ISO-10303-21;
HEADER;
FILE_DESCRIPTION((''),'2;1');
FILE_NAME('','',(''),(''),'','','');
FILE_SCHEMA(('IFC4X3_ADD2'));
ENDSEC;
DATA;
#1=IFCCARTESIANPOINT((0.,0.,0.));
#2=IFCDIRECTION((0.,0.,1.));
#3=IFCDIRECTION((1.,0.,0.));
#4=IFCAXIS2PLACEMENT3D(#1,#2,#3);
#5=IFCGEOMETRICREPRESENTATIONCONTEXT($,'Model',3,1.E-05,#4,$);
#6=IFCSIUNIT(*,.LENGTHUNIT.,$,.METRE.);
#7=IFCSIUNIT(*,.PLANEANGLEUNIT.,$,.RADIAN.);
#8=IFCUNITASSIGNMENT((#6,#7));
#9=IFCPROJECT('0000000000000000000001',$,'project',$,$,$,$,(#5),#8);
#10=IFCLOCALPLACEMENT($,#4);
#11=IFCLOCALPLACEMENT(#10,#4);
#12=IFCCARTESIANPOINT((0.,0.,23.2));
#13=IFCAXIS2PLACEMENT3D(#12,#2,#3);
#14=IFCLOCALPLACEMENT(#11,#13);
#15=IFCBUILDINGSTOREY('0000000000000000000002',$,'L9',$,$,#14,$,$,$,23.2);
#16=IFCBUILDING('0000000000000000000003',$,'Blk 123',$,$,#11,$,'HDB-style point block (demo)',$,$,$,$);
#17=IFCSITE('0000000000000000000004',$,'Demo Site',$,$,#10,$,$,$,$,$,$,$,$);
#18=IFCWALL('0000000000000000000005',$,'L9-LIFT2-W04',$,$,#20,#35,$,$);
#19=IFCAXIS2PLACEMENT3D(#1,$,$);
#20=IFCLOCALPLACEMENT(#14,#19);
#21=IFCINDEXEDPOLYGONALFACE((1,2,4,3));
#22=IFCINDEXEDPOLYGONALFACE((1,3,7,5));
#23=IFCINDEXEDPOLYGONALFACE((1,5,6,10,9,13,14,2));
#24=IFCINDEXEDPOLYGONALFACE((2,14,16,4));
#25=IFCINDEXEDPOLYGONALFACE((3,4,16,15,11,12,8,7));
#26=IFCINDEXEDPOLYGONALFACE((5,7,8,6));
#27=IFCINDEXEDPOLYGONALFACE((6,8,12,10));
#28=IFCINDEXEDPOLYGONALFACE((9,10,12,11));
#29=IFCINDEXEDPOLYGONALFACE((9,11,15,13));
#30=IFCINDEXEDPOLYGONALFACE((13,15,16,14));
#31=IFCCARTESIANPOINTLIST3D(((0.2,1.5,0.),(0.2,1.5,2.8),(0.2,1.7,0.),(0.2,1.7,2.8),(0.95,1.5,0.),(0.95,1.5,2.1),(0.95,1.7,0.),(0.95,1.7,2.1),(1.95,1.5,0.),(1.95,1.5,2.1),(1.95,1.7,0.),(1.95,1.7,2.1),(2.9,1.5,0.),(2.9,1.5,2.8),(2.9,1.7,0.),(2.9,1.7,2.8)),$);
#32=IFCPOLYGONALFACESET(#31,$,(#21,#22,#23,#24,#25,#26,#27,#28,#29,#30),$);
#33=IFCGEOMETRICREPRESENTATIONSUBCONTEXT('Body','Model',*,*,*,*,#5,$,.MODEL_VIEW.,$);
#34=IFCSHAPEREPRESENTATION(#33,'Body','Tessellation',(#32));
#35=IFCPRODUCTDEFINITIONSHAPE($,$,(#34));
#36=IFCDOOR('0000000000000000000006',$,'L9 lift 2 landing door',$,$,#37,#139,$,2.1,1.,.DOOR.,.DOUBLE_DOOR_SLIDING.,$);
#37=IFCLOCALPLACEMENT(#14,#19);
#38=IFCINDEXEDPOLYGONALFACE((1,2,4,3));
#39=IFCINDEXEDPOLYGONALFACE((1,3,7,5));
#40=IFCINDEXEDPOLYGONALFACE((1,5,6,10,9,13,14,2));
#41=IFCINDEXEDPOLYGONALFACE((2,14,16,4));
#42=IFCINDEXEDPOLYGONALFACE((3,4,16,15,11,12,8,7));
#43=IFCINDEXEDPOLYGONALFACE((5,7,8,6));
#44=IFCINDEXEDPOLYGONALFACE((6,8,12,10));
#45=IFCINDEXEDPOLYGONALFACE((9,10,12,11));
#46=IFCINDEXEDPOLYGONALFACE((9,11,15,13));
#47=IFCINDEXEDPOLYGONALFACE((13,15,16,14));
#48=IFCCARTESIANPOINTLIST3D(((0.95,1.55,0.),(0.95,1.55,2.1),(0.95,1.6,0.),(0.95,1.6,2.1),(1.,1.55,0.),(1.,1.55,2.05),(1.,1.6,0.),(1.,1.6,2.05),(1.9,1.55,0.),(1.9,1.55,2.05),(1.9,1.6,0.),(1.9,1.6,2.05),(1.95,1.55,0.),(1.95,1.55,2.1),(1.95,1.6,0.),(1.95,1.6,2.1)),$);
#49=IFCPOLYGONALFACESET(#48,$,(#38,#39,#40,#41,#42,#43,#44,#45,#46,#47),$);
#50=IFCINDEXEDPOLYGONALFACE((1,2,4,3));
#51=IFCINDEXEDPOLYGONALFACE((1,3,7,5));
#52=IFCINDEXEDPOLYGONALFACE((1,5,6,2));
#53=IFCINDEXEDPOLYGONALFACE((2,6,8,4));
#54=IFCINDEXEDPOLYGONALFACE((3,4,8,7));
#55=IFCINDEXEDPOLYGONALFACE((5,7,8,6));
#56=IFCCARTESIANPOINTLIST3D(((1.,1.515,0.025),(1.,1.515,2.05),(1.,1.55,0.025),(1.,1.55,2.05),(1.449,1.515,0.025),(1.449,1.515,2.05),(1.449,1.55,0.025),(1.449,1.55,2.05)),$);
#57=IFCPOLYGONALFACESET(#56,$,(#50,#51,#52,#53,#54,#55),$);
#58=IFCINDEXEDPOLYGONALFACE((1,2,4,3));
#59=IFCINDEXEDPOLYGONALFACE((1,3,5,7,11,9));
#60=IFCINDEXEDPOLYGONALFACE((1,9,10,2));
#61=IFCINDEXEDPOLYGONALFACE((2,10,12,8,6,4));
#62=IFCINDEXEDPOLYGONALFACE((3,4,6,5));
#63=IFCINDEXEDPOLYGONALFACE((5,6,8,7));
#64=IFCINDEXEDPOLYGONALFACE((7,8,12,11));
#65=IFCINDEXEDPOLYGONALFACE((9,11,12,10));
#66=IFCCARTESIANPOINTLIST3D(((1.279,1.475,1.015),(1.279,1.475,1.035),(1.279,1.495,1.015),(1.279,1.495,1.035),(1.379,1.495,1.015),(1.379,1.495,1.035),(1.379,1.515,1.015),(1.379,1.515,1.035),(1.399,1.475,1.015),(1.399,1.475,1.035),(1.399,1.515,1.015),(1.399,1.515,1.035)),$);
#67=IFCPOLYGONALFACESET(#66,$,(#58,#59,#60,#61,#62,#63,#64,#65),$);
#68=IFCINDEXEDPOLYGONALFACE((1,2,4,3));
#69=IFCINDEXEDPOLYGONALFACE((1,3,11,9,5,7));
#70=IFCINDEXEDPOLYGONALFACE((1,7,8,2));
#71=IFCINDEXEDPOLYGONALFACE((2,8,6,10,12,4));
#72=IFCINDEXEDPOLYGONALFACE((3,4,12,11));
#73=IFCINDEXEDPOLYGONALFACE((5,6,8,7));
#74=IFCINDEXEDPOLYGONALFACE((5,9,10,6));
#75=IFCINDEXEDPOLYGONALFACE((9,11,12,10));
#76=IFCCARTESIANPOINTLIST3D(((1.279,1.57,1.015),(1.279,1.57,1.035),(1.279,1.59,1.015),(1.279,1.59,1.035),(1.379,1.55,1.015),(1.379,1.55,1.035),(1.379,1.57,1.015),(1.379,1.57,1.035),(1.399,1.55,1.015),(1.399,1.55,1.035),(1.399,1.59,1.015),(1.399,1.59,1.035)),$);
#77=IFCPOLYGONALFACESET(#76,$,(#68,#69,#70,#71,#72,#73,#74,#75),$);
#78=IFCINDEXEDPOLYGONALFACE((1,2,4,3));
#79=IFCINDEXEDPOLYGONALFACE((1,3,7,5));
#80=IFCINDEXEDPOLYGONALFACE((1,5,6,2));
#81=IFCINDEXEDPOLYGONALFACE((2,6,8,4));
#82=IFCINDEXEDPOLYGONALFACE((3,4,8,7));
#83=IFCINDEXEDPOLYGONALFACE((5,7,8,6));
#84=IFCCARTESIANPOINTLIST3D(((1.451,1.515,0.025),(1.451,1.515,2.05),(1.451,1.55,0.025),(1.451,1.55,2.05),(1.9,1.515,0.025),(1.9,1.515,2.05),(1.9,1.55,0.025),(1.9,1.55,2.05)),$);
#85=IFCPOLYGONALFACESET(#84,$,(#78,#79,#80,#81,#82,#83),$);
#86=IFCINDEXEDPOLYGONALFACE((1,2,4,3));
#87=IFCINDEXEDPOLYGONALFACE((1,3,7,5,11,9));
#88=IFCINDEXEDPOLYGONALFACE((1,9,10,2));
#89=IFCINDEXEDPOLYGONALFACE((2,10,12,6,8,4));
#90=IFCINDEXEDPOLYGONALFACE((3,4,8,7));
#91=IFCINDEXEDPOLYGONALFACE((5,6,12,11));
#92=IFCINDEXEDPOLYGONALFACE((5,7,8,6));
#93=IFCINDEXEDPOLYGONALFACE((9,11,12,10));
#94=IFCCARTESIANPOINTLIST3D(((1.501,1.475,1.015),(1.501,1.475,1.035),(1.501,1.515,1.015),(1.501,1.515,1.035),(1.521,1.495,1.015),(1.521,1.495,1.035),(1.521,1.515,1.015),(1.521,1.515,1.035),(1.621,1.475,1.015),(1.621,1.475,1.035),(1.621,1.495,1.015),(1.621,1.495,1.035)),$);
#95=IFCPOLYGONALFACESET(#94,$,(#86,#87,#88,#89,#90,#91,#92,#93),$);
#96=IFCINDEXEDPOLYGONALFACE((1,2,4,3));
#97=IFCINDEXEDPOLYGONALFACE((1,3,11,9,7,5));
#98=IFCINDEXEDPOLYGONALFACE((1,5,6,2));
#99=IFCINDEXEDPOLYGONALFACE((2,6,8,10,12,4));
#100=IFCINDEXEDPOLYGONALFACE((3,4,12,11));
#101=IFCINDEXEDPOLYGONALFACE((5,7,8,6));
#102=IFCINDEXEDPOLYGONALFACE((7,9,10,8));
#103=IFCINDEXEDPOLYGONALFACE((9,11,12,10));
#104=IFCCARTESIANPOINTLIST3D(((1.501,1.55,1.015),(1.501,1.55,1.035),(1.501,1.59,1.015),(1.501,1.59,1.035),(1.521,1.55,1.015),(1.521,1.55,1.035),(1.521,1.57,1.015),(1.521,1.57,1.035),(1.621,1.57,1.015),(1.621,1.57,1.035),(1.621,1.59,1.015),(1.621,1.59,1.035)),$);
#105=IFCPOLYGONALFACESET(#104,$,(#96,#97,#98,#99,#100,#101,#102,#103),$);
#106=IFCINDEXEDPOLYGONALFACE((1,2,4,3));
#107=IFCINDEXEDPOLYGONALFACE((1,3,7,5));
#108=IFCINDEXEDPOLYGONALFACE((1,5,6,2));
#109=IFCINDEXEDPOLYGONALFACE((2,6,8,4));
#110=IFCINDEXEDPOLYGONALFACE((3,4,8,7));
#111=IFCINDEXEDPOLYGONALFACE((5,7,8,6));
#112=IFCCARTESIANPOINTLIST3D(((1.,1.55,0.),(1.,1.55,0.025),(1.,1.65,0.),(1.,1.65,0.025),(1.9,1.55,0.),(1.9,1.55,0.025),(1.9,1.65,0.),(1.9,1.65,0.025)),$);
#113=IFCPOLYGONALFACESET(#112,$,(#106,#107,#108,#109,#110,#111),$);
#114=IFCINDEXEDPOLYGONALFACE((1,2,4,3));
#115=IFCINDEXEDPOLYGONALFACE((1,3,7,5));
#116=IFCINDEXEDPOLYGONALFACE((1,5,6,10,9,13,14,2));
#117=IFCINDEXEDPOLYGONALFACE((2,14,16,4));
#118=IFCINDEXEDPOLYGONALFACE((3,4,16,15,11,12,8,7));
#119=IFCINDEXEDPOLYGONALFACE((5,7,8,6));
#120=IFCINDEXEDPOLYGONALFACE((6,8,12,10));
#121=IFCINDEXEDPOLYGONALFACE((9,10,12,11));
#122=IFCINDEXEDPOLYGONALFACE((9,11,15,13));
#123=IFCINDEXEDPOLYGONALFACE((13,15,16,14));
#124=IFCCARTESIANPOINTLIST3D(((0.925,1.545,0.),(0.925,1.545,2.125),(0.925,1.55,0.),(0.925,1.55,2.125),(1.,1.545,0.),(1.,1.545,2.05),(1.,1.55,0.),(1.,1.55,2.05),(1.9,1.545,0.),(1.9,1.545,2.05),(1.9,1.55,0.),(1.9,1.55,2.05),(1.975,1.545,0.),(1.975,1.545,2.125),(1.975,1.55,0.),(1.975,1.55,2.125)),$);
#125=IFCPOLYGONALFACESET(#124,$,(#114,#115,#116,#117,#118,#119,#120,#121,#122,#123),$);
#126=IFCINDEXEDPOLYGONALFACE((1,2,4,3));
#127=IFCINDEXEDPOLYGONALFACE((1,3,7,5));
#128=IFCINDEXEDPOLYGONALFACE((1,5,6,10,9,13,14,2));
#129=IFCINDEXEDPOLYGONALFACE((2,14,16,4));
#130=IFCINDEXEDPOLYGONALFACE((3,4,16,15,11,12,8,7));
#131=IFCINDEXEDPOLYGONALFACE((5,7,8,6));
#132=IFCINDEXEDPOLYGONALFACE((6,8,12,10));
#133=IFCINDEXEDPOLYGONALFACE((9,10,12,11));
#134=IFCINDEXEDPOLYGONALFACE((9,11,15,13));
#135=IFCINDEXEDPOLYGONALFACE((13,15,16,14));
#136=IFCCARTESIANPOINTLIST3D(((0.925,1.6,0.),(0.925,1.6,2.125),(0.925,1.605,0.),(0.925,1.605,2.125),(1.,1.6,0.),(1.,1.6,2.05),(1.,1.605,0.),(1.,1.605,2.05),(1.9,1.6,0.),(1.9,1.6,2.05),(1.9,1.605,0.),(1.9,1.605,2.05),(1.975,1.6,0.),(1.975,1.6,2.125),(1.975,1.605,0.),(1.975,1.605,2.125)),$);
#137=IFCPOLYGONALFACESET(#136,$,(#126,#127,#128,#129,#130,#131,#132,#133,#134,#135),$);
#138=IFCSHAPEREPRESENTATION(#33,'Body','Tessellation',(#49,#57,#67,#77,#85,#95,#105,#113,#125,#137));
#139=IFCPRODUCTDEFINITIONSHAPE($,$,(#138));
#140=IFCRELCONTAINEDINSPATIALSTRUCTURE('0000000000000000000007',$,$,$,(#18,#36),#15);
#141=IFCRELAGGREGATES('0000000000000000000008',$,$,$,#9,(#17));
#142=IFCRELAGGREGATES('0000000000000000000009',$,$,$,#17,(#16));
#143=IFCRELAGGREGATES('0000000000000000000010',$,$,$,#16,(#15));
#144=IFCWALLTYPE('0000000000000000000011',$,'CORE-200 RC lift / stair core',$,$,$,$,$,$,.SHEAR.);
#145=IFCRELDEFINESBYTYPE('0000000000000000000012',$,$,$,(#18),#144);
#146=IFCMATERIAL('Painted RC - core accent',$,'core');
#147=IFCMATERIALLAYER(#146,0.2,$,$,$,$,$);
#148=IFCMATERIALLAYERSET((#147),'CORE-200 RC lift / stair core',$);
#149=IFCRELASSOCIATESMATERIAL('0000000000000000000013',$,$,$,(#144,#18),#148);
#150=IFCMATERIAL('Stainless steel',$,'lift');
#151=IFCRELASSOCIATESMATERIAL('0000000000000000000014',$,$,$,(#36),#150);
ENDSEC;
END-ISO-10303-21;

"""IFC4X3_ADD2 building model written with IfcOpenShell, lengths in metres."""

from ifc_helpers import new_model, si_unit, frame, origin_with_axes, place, context, subcontext, project, spatial, line, indexed_curve, outline, extrude, material, layer, layer_set, layer_usage, type_object, element, fill, save


model = new_model("IFC4X3_ADD2")

# Units and contexts
model_context = context("Model", 3, precision=1e-05, world=origin_with_axes())
body_context = subcontext(model_context, "Body", "Model", "MODEL_VIEW")
ifc_project = project(units=[si_unit("LENGTHUNIT", "METRE"), si_unit("PLANEANGLEUNIT", "RADIAN")], contexts=[model_context])

# Site, building, storey
site_placement = place(None, origin_with_axes())
site = spatial("IfcSite", under=ifc_project, at=site_placement, Name="Demo Site")
building_placement = place(site_placement, origin_with_axes())
building = spatial("IfcBuilding", under=site, at=building_placement, Name="Blk 123", LongName="HDB-style point block (demo)")
storey_placement = place(building_placement, frame((0.0, 0.0, 23.2), z_axis=(0.0, 0.0, 1.0), x_axis=(1.0, 0.0, 0.0)))
storey = spatial("IfcBuildingStorey", under=building, at=storey_placement, Name="L9", Elevation=23.2)

# Shared definitions
ifc_material_1 = material(Name="Painted RC - core accent", Category="core")
ifc_layer_1 = layer(ifc_material_1, 0.2)
ifc_layer_set_1 = layer_set([ifc_layer_1], Name="CORE-200 RC lift / stair core")
ifc_layer_usage_1 = layer_usage(ifc_layer_set_1, "AXIS2", "POSITIVE", 0.0)
wall_type_1 = type_object("IfcWallType", Name="CORE-200 RC lift / stair core", PredefinedType="SHEAR", material=ifc_layer_set_1)

# Wall, opening, door
wall_1_placement = place(storey_placement, frame((0.2, 1.5, 0.0), z_axis=(0.0, 0.0, 1.0), x_axis=(1.0, 0.0, 0.0)))
wall_1 = element("IfcWall", 1, at=wall_1_placement, inside=storey, type_object=wall_type_1, material=ifc_layer_usage_1, Name="L9-LIFT2-W04", context=body_context, shape_type="SweptSolid", body=[
    extrude(outline(indexed_curve([(0.0, 0.0), (0.0, 0.2), (2.7, 0.2), (2.7, 0.0), (0.0, 0.0)], self_intersect=False)), origin_with_axes(), (0.0, 0.0, 1.0), 2.8),
])
opening_1_placement = place(wall_1_placement, frame((0.75, -0.1, 0.0), z_axis=(0.0, 0.0, 1.0), x_axis=(1.0, 0.0, 0.0)))
opening_1 = element("IfcOpeningElement", 2, at=opening_1_placement, cuts=wall_1, context=body_context, shape_type="SweptSolid", body=[
    extrude(outline(indexed_curve([(0.0, 0.0), (0.0, 0.4), (1.0, 0.4), (1.0, 0.0), (0.0, 0.0)], self_intersect=False)), origin_with_axes(), (0.0, 0.0, 1.0), 2.1),
])
ifc_material_2 = material(Name="Stainless steel", Category="lift")
door_1_placement = place(opening_1_placement, frame((0.0, 0.15, 0.0), z_axis=(0.0, 0.0, 1.0), x_axis=(1.0, 0.0, 0.0)))
door_1 = element("IfcDoor", 3, at=door_1_placement, inside=storey, material=ifc_material_2, Name="L9 lift 2 landing door", OperationType="DOUBLE_DOOR_SLIDING", OverallHeight=2.1, OverallWidth=1.0, PredefinedType="DOOR", context=body_context, shape_type="SweptSolid", body=[
    extrude(outline(indexed_curve([(0.0, 0.0), (0.0, 2.1), (1.0, 2.1), (1.0, 0.0), (0.95, 0.0), (0.95, 2.05), (0.05, 2.05), (0.05, 0.0)], segments=[line(1, 2, 3, 4, 5, 6, 7, 8, 1)])), frame((0.0, 0.0, 0.0), z_axis=(0.0, -1.0, 0.0), x_axis=(1.0, 0.0, 0.0)), (0.0, 0.0, -1.0), 0.05),
    extrude(outline(indexed_curve([(0.0, 0.0), (0.449, 0.0), (0.449, 0.035), (0.0, 0.035)], segments=[line(1, 2, 3, 4, 1)])), frame((0.05, -0.035, 0.025), z_axis=(0.0, 0.0, 1.0), x_axis=(1.0, 0.0, 0.0)), (0.0, 0.0, 1.0), 2.025),
    extrude(outline(indexed_curve([(0.0, 0.0), (0.0, -0.04), (-0.12, -0.04), (-0.12, -0.02), (-0.02, -0.02), (-0.02, 0.0)], segments=[line(1, 2, 3, 4, 5, 6, 1)])), frame((0.449, -0.035, 1.015), z_axis=(0.0, 0.0, 1.0), x_axis=(1.0, 0.0, 0.0)), (0.0, 0.0, 1.0), 0.02),
    extrude(outline(indexed_curve([(0.0, 0.0), (0.0, 0.04), (-0.12, 0.04), (-0.12, 0.02), (-0.02, 0.02), (-0.02, 0.0)], segments=[line(1, 2, 3, 4, 5, 6, 1)])), frame((0.449, 0.0, 1.015), z_axis=(0.0, 0.0, 1.0), x_axis=(1.0, 0.0, 0.0)), (0.0, 0.0, 1.0), 0.02),
    extrude(outline(indexed_curve([(0.0, 0.0), (-0.449, 0.0), (-0.449, 0.035), (0.0, 0.035)], segments=[line(1, 2, 3, 4, 1)])), frame((0.95, -0.035, 0.025), z_axis=(0.0, 0.0, 1.0), x_axis=(1.0, 0.0, 0.0)), (0.0, 0.0, 1.0), 2.025),
    extrude(outline(indexed_curve([(0.0, 0.0), (0.0, -0.04), (0.12, -0.04), (0.12, -0.02), (0.02, -0.02), (0.02, 0.0)], segments=[line(1, 2, 3, 4, 5, 6, 1)])), frame((0.551, -0.035, 1.015), z_axis=(0.0, 0.0, 1.0), x_axis=(1.0, 0.0, 0.0)), (0.0, 0.0, 1.0), 0.02),
    extrude(outline(indexed_curve([(0.0, 0.0), (0.0, 0.04), (0.12, 0.04), (0.12, 0.02), (0.02, 0.02), (0.02, 0.0)], segments=[line(1, 2, 3, 4, 5, 6, 1)])), frame((0.551, 0.0, 1.015), z_axis=(0.0, 0.0, 1.0), x_axis=(1.0, 0.0, 0.0)), (0.0, 0.0, 1.0), 0.02),
    extrude(outline(indexed_curve([(0.0, 0.0), (0.9, 0.0), (0.9, 0.1), (0.0, 0.1)], segments=[line(1, 2, 3, 4, 1)])), frame((0.05, 0.0, 0.0), z_axis=(0.0, 0.0, 1.0), x_axis=(1.0, 0.0, 0.0)), (0.0, 0.0, 1.0), 0.025),
    extrude(outline(indexed_curve([(0.0, 0.0), (0.0, 2.125), (1.05, 2.125), (1.05, 0.0), (0.975, 0.0), (0.975, 2.05), (0.075, 2.05), (0.075, 0.0)], segments=[line(1, 2, 3, 4, 5, 6, 7, 8, 1)])), frame((-0.025, -0.005, 0.0), z_axis=(0.0, -1.0, 0.0), x_axis=(1.0, 0.0, 0.0)), (0.0, 0.0, -1.0), 0.005),
    extrude(outline(indexed_curve([(0.0, 0.0), (0.0, 2.125), (1.05, 2.125), (1.05, 0.0), (0.975, 0.0), (0.975, 2.05), (0.075, 2.05), (0.075, 0.0)], segments=[line(1, 2, 3, 4, 5, 6, 7, 8, 1)])), frame((-0.025, 0.05, 0.0), z_axis=(0.0, -1.0, 0.0), x_axis=(1.0, 0.0, 0.0)), (0.0, 0.0, -1.0), 0.005),
])
fill(opening_1, door_1)

save(model, "model.ifc")
